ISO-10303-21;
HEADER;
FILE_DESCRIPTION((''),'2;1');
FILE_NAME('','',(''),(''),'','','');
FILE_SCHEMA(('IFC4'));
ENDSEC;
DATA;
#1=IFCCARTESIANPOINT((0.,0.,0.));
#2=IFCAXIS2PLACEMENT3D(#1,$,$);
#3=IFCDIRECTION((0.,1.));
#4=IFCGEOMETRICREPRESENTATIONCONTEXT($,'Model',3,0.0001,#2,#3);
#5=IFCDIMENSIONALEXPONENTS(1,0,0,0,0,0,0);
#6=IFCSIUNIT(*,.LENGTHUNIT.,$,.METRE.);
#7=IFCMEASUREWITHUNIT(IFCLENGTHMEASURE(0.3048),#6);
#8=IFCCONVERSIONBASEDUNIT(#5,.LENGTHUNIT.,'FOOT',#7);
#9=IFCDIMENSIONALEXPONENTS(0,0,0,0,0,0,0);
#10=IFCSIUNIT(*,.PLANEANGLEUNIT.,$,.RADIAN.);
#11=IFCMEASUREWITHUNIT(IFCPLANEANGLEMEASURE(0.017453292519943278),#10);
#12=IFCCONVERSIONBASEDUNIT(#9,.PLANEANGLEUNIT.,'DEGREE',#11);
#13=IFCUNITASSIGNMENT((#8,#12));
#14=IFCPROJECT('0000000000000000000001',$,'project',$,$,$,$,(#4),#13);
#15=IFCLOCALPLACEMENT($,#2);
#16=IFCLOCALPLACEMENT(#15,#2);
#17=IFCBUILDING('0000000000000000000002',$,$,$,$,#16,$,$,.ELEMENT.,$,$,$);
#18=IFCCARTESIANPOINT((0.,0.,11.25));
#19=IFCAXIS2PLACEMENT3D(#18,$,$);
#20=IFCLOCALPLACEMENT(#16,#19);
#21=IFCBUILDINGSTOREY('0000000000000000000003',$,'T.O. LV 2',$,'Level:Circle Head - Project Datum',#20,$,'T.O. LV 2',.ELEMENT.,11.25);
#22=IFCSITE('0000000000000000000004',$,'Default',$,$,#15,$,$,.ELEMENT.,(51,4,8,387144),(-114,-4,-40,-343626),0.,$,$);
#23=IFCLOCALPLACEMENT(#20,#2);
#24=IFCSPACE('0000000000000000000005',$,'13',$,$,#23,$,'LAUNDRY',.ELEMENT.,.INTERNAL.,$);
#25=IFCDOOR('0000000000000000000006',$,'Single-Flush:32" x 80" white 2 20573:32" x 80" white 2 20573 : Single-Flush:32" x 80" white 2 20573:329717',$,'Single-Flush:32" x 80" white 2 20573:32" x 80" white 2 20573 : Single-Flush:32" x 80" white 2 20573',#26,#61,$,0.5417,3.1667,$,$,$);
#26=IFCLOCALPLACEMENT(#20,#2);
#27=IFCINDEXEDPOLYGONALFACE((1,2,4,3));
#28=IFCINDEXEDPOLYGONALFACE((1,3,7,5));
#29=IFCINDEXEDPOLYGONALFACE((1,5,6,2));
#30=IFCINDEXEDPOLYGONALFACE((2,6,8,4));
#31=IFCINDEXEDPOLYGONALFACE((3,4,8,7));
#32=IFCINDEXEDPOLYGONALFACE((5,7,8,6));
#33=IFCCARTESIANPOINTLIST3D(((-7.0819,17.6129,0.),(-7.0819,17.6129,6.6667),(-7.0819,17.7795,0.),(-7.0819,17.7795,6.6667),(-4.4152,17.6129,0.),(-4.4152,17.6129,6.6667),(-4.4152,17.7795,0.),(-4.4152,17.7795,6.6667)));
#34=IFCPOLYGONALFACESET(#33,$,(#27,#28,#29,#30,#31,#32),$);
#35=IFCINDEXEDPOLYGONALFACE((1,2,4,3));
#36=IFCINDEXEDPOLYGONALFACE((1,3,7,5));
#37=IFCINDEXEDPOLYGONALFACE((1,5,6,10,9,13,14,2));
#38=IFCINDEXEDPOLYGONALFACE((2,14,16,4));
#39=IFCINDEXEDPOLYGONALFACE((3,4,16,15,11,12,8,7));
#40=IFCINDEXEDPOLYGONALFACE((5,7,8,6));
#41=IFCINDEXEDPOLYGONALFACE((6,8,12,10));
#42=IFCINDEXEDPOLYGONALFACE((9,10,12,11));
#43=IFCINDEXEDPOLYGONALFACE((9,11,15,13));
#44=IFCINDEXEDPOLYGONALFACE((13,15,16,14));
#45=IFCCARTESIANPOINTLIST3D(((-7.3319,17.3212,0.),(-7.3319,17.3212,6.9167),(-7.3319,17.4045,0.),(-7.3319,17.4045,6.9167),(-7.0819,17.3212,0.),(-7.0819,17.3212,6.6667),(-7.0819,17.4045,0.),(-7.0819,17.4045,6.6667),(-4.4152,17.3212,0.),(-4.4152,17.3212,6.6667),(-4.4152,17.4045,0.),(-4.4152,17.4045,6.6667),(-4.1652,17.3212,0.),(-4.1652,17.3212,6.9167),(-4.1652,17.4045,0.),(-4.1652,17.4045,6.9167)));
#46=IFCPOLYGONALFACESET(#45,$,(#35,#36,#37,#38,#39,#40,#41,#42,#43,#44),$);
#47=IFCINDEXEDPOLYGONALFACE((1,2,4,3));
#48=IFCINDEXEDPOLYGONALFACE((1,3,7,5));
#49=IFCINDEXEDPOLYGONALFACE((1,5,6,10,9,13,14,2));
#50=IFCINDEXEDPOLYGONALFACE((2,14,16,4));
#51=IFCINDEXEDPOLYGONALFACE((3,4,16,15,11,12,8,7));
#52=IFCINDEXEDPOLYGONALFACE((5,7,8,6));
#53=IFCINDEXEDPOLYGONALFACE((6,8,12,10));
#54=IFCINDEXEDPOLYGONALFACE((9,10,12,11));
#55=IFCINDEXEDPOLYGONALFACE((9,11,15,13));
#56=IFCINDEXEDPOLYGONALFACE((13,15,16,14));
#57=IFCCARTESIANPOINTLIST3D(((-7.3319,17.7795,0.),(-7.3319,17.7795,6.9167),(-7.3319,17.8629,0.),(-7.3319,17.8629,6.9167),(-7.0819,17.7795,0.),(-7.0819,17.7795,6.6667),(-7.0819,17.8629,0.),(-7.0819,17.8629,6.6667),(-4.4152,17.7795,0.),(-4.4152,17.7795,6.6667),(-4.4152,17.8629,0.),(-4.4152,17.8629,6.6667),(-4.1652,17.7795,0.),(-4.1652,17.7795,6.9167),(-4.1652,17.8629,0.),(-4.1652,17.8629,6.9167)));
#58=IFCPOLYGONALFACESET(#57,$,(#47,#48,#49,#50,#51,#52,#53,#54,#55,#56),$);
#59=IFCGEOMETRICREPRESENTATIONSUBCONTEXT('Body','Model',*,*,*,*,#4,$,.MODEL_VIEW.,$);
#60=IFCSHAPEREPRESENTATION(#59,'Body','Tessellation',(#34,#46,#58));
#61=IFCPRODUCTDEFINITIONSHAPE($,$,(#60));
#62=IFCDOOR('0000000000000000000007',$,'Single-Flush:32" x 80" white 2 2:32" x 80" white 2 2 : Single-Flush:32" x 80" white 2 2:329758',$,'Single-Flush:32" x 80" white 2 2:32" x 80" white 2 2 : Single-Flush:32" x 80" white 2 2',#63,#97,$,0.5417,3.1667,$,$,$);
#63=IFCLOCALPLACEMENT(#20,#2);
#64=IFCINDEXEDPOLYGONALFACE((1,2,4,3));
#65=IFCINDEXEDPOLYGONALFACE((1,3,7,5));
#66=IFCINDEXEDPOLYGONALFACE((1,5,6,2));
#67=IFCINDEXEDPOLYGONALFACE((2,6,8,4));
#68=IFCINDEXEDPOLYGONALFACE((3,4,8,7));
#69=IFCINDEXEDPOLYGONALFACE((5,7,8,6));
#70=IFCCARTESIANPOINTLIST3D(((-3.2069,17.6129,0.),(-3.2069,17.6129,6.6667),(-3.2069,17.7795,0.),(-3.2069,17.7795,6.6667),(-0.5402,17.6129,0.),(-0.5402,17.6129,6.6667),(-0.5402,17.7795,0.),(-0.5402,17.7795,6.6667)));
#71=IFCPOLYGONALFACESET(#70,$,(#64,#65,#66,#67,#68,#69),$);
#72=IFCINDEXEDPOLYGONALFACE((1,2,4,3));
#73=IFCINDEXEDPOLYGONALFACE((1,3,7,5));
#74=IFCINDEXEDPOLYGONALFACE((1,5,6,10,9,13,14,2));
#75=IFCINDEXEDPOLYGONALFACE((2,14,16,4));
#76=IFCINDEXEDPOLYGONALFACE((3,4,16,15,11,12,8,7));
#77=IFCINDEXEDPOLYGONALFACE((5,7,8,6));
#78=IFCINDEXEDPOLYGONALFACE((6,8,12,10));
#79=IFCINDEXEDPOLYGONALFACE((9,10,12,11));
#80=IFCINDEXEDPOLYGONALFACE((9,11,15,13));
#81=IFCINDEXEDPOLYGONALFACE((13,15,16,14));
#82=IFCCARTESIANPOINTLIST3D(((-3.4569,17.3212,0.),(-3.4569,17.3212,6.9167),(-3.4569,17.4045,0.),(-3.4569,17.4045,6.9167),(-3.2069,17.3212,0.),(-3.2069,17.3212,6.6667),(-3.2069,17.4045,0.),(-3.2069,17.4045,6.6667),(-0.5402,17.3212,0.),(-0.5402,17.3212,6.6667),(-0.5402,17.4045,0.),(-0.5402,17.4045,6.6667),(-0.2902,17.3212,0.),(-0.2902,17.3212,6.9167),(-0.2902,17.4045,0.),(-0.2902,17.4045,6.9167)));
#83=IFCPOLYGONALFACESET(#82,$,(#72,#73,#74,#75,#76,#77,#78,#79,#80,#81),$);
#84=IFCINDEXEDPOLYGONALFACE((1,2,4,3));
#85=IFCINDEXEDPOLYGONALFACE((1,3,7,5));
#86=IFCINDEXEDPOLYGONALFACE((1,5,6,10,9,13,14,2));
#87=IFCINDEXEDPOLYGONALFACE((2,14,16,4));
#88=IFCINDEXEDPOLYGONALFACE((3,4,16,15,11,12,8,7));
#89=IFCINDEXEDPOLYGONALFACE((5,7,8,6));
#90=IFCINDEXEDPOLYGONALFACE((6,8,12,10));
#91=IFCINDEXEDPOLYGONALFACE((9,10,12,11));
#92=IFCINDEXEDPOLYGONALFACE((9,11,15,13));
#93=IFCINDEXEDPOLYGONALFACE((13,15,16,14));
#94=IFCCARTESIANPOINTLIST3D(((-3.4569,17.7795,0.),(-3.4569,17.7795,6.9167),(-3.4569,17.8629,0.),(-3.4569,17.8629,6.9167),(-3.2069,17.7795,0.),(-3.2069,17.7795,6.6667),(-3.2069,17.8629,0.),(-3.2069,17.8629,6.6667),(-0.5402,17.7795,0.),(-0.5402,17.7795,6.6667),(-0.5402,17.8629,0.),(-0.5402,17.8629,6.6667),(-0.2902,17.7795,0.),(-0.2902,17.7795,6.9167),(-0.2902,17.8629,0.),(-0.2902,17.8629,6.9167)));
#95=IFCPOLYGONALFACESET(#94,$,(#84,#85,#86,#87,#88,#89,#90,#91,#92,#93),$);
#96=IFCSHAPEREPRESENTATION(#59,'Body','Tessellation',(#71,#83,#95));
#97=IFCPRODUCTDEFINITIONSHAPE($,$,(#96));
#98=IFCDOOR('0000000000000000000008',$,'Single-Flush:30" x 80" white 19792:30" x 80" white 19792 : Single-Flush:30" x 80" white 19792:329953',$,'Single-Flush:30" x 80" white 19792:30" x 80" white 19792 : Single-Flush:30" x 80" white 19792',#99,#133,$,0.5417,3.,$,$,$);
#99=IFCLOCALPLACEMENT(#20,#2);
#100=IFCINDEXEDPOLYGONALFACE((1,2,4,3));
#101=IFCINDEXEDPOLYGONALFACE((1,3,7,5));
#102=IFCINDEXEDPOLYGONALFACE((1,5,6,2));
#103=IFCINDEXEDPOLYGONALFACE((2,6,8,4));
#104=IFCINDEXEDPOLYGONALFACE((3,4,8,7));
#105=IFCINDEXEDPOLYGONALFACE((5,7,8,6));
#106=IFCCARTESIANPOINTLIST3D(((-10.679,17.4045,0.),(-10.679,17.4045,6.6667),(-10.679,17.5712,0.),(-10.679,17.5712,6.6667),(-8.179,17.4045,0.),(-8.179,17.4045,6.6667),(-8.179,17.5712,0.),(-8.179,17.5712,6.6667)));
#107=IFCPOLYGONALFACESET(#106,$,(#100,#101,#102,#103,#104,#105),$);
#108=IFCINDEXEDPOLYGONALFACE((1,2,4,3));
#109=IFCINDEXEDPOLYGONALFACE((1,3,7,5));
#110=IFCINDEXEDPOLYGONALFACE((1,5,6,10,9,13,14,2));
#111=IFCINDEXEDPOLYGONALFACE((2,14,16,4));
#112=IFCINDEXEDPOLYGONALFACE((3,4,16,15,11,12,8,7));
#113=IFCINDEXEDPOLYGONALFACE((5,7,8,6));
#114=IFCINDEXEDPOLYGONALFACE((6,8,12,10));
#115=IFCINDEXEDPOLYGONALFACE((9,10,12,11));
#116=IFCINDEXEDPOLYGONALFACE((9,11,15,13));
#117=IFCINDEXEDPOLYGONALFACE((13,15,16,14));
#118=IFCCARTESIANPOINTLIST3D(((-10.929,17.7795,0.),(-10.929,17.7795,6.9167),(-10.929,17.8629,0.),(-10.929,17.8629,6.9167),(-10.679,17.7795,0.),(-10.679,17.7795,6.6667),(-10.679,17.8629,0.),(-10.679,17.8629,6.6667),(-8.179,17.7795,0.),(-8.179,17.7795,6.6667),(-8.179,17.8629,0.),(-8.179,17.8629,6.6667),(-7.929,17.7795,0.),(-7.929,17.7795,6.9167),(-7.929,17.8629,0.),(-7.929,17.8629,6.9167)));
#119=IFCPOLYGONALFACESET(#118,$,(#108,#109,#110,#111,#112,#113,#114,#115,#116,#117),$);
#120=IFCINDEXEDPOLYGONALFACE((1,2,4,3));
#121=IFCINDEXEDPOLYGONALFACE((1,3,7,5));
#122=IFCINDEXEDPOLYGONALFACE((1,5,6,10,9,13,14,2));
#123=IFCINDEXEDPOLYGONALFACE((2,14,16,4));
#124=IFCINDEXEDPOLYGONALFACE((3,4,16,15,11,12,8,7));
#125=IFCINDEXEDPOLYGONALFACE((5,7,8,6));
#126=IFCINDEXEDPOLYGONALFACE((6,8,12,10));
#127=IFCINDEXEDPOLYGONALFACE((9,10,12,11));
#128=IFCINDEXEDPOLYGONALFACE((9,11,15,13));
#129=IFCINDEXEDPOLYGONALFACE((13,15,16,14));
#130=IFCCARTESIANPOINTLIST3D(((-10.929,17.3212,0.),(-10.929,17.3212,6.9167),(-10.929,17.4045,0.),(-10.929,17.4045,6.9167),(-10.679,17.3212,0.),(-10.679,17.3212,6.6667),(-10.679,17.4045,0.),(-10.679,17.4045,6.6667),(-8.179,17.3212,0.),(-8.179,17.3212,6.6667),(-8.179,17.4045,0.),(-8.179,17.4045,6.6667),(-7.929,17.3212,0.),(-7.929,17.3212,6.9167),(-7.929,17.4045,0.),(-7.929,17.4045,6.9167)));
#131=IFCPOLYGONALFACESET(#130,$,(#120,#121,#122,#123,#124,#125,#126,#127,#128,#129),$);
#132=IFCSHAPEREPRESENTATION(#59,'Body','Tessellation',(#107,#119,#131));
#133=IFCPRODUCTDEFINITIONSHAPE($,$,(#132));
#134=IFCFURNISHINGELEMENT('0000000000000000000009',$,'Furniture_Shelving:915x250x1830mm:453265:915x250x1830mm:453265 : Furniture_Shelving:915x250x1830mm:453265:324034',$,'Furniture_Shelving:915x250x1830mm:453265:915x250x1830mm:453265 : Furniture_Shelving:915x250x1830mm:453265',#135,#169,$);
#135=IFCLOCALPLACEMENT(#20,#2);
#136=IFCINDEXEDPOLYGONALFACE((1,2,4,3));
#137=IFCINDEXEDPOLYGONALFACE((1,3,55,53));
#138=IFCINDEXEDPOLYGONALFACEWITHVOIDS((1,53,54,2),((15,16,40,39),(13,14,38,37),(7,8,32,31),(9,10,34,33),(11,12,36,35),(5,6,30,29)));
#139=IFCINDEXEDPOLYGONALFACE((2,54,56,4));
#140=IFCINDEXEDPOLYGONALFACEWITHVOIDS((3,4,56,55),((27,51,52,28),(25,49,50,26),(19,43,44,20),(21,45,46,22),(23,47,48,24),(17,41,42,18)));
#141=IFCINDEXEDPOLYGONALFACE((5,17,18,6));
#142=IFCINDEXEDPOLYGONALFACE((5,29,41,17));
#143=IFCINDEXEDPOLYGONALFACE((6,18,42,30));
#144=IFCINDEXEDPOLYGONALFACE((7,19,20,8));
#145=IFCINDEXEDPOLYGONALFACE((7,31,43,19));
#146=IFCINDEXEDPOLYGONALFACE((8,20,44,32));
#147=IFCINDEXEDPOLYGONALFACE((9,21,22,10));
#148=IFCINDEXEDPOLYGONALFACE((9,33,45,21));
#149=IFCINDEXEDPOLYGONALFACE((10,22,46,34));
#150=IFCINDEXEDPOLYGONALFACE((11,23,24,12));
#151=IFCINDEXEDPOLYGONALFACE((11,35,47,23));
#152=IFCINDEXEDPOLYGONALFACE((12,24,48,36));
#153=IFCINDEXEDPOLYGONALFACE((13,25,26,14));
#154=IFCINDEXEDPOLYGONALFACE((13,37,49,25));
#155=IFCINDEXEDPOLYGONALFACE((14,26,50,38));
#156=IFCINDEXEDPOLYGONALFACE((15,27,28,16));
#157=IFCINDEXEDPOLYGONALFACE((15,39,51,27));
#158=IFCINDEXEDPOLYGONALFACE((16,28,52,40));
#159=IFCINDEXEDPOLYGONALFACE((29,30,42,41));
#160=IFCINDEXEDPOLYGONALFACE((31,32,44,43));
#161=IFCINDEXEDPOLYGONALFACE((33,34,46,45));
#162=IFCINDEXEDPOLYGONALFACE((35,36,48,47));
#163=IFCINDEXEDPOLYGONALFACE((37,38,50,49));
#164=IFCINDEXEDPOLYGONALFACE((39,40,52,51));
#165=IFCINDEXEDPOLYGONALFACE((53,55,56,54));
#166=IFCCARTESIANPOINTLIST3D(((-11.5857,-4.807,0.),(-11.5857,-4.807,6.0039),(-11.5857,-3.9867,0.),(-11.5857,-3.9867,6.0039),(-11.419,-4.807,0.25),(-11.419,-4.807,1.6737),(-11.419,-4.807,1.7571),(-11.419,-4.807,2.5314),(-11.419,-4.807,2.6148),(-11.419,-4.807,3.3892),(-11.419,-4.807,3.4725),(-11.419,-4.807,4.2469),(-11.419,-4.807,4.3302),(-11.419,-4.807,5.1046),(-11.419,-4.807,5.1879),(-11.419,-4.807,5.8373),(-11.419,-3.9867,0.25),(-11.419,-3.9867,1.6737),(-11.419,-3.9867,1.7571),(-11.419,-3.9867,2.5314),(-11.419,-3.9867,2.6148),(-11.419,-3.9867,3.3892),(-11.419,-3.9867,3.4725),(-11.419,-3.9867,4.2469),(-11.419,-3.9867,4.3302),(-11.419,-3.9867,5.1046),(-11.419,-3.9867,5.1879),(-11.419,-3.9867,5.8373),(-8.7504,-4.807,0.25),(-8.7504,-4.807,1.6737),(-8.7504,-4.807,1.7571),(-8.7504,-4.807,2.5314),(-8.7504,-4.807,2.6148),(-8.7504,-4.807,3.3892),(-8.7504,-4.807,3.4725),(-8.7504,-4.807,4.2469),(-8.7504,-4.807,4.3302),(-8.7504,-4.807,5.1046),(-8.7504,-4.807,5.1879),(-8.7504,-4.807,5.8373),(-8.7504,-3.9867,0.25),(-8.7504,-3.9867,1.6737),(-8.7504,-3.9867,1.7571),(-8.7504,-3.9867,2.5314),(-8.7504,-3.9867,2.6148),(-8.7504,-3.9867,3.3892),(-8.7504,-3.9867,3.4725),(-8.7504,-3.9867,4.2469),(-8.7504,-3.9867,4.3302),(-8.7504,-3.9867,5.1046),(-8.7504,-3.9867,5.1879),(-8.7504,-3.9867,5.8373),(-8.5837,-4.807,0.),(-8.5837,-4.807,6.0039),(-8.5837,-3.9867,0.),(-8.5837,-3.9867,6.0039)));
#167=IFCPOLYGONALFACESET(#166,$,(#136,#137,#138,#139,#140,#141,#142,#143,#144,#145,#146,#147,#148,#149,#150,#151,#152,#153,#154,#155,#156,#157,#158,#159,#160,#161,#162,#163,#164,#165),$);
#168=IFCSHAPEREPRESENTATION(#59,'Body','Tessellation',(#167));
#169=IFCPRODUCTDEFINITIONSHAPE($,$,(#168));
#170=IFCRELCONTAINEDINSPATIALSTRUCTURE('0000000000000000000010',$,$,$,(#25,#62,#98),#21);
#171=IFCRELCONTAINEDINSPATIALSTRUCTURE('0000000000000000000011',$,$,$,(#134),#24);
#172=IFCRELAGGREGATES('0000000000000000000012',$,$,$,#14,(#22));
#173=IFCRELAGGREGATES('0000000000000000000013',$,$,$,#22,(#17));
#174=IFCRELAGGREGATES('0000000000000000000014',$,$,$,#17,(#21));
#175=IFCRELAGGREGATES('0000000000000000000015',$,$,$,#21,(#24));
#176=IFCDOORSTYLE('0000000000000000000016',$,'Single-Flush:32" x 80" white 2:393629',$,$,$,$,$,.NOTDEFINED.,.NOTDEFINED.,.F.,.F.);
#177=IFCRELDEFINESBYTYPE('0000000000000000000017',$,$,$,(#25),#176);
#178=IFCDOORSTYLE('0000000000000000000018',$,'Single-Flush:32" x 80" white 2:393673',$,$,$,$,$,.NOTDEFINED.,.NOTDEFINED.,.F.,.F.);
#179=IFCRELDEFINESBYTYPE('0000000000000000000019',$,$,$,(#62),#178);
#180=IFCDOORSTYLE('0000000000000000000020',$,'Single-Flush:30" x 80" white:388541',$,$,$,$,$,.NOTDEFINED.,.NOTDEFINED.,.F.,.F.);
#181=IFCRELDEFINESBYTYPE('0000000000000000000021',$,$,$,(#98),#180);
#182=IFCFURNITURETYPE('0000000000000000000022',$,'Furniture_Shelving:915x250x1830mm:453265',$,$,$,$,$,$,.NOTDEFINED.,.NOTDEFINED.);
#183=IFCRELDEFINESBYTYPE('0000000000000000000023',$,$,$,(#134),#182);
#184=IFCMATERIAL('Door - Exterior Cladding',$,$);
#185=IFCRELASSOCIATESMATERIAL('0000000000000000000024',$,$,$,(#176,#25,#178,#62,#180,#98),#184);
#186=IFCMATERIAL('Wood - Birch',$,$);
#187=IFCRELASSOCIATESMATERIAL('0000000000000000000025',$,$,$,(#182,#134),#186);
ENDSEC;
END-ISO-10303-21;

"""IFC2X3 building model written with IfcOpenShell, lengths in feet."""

from ifc_helpers import new_model, entity, si_unit, converted_unit, direction, frame, frame_2d, origin, place, context, subcontext, project, spatial, polyline, rectangle, outline, extrude, source, transform, mapped, material, type_object, type_shapes, element, save


model = new_model("IFC2X3")

# Units and contexts
model_context = context("Model", 3, precision=0.0001, world=origin(), true_north=direction((0.0, 1.0)))
body_context = subcontext(model_context, "Body", "Model", "MODEL_VIEW")
ifc_project = project(units=[converted_unit("LENGTHUNIT", "FOOT", entity("IfcLengthMeasure", 0.3048), si_unit("LENGTHUNIT", "METRE"), dimensions=[1, 0, 0, 0, 0, 0, 0]), converted_unit("PLANEANGLEUNIT", "DEGREE", entity("IfcPlaneAngleMeasure", 0.017453292519943278), si_unit("PLANEANGLEUNIT", "RADIAN"), dimensions=[0, 0, 0, 0, 0, 0, 0])], contexts=[model_context])

# Site, building, storey
site_placement = place(None, origin())
site = spatial("IfcSite", under=ifc_project, at=site_placement, Name="Default", CompositionType="ELEMENT", RefLatitude=(51, 4, 8, 387144), RefLongitude=(-114, -4, -40, -343626), RefElevation=0.0)
building_placement = place(site_placement, origin())
building = spatial("IfcBuilding", under=site, at=building_placement, CompositionType="ELEMENT")
storey_placement = place(building_placement, frame((0.0, 0.0, 11.25)))
storey = spatial("IfcBuildingStorey", under=building, at=storey_placement, Name="T.O. LV 2", ObjectType="Level:Circle Head - Project Datum", LongName="T.O. LV 2", CompositionType="ELEMENT", Elevation=11.25)

# Shared definitions
ifc_material_1 = material(Name="Door - Exterior Cladding")

# Doors
door_style_1 = type_object("IfcDoorStyle", Name="Single-Flush:32\" x 80\" white 2:393629", ConstructionType="NOTDEFINED", OperationType="NOTDEFINED", ParameterTakesPrecedence=False, Sizeable=False, material=ifc_material_1)
shared_shape_1 = source(origin(), body_context, "Body", "SweptSolid", [
    extrude(rectangle(XDim=2.6667, YDim=0.1667, at=frame_2d((0.0, 0.0), x_axis=(1.0, 0.0))), frame((-5.7486, 17.6962, 11.25), z_axis=(0.0, 0.0, 1.0), x_axis=(-1.0, 0.0, 0.0)), (0.0, 0.0, 1.0), 6.6667),
    extrude(outline(polyline([(-1.5833, -3.3958), (-1.3333, -3.3958), (-1.3333, 3.2708), (1.3333, 3.2708), (1.3333, -3.3958), (1.5833, -3.3958), (1.5833, 3.5208), (-1.5833, 3.5208), (-1.5833, -3.3958)])), frame((-5.7486, 17.3212, 14.6458), z_axis=(0.0, 1.0, 0.0), x_axis=(-1.0, 0.0, 0.0)), (0.0, 0.0, 1.0), 0.0833),
    extrude(outline(polyline([(-3.5208, -1.5833), (3.3958, -1.5833), (3.3958, -1.3333), (-3.2708, -1.3333), (-3.2708, 1.3333), (3.3958, 1.3333), (3.3958, 1.5833), (-3.5208, 1.5833), (-3.5208, -1.5833)])), frame((-5.7486, 17.7795, 14.6458), z_axis=(0.0, 1.0, 0.0), x_axis=(0.0, 0.0, -1.0)), (0.0, 0.0, 1.0), 0.0833),
])
type_shapes(door_style_1, [shared_shape_1])
door_1_placement = place(storey_placement, frame((0.0, 0.0, -11.25)))
element("IfcDoor", 1, at=door_1_placement, inside=storey, type_object=door_style_1, material=ifc_material_1, Name="Single-Flush:32\" x 80\" white 2 20573:32\" x 80\" white 2 20573 : Single-Flush:32\" x 80\" white 2 20573:329717", ObjectType="Single-Flush:32\" x 80\" white 2 20573:32\" x 80\" white 2 20573 : Single-Flush:32\" x 80\" white 2 20573", OverallHeight=0.5417, OverallWidth=3.1667, context=body_context, shape_type="MappedRepresentation", body=[
    mapped(shared_shape_1, transform((0.0, 0.0, 0.0), scale=1.0)),
])
door_style_2 = type_object("IfcDoorStyle", Name="Single-Flush:32\" x 80\" white 2:393673", ConstructionType="NOTDEFINED", OperationType="NOTDEFINED", ParameterTakesPrecedence=False, Sizeable=False, material=ifc_material_1)
shared_shape_2 = source(origin(), body_context, "Body", "SweptSolid", [
    extrude(rectangle(XDim=0.1667, YDim=2.6667, at=frame_2d((0.0, 0.0), x_axis=(1.0, 0.0))), frame((-1.8736, 17.6962, 11.25), z_axis=(0.0, 0.0, 1.0), x_axis=(0.0, 1.0, 0.0)), (0.0, 0.0, 1.0), 6.6667),
    extrude(outline(polyline([(-3.3958, -1.5833), (3.5208, -1.5833), (3.5208, 1.5833), (-3.3958, 1.5833), (-3.3958, 1.3333), (3.2708, 1.3333), (3.2708, -1.3333), (-3.3958, -1.3333), (-3.3958, -1.5833)])), frame((-1.8736, 17.3212, 14.6458), z_axis=(0.0, 1.0, 0.0), x_axis=(0.0, 0.0, 1.0)), (0.0, 0.0, 1.0), 0.0833),
    extrude(outline(polyline([(-1.5833, -3.5208), (1.5833, -3.5208), (1.5833, 3.3958), (1.3333, 3.3958), (1.3333, -3.2708), (-1.3333, -3.2708), (-1.3333, 3.3958), (-1.5833, 3.3958), (-1.5833, -3.5208)])), frame((-1.8736, 17.7795, 14.6458), z_axis=(0.0, 1.0, 0.0), x_axis=(1.0, 0.0, 0.0)), (0.0, 0.0, 1.0), 0.0833),
])
type_shapes(door_style_2, [shared_shape_2])
door_2_placement = place(storey_placement, frame((0.0, 0.0, -11.25)))
element("IfcDoor", 2, at=door_2_placement, inside=storey, type_object=door_style_2, material=ifc_material_1, Name="Single-Flush:32\" x 80\" white 2 2:32\" x 80\" white 2 2 : Single-Flush:32\" x 80\" white 2 2:329758", ObjectType="Single-Flush:32\" x 80\" white 2 2:32\" x 80\" white 2 2 : Single-Flush:32\" x 80\" white 2 2", OverallHeight=0.5417, OverallWidth=3.1667, context=body_context, shape_type="MappedRepresentation", body=[
    mapped(shared_shape_2, transform((0.0, 0.0, 0.0), scale=1.0)),
])
door_style_3 = type_object("IfcDoorStyle", Name="Single-Flush:30\" x 80\" white:388541", ConstructionType="NOTDEFINED", OperationType="NOTDEFINED", ParameterTakesPrecedence=False, Sizeable=False, material=ifc_material_1)
shared_shape_3 = source(origin(), body_context, "Body", "SweptSolid", [
    extrude(rectangle(XDim=2.5, YDim=0.1667, at=frame_2d((0.0, 0.0), x_axis=(1.0, 0.0))), frame((-9.429, 17.4879, 11.25)), (0.0, 0.0, 1.0), 6.6667),
    extrude(outline(polyline([(-3.3958, -1.5), (3.5208, -1.5), (3.5208, 1.5), (-3.3958, 1.5), (-3.3958, 1.25), (3.2708, 1.25), (3.2708, -1.25), (-3.3958, -1.25), (-3.3958, -1.5)])), frame((-9.429, 17.7795, 14.6458), z_axis=(0.0, 1.0, 0.0), x_axis=(0.0, 0.0, 1.0)), (0.0, 0.0, 1.0), 0.0833),
    extrude(outline(polyline([(-1.5, -3.5208), (1.5, -3.5208), (1.5, 3.3958), (1.25, 3.3958), (1.25, -3.2708), (-1.25, -3.2708), (-1.25, 3.3958), (-1.5, 3.3958), (-1.5, -3.5208)])), frame((-9.429, 17.3212, 14.6458), z_axis=(0.0, 1.0, 0.0), x_axis=(1.0, 0.0, 0.0)), (0.0, 0.0, 1.0), 0.0833),
])
type_shapes(door_style_3, [shared_shape_3])
door_3_placement = place(storey_placement, frame((0.0, 0.0, -11.25)))
element("IfcDoor", 3, at=door_3_placement, inside=storey, type_object=door_style_3, material=ifc_material_1, Name="Single-Flush:30\" x 80\" white 19792:30\" x 80\" white 19792 : Single-Flush:30\" x 80\" white 19792:329953", ObjectType="Single-Flush:30\" x 80\" white 19792:30\" x 80\" white 19792 : Single-Flush:30\" x 80\" white 19792", OverallHeight=0.5417, OverallWidth=3.0, context=body_context, shape_type="MappedRepresentation", body=[
    mapped(shared_shape_3, transform((0.0, 0.0, 0.0), scale=1.0)),
])

# Shared definitions
space_placement = place(storey_placement, origin())
space = spatial("IfcSpace", under=storey, at=space_placement, Name="13", LongName="LAUNDRY", CompositionType="ELEMENT", InteriorOrExteriorSpace="INTERNAL")

# Furnishing element
ifc_material_2 = material(Name="Wood - Birch")
furniture_type = type_object("IfcFurnitureType", Name="Furniture_Shelving:915x250x1830mm:453265", AssemblyPlace="NOTDEFINED", material=ifc_material_2)
shared_shape_4 = source(origin(), body_context, "Body", "SweptSolid", [
    extrude(outline(polyline([(-3.002, -1.501), (3.002, -1.501), (3.002, 1.501), (-3.002, 1.501), (-3.002, -1.501)]), holes=[polyline([(2.8353, -1.3343), (2.1859, -1.3343), (2.1859, 1.3343), (2.8353, 1.3343), (2.8353, -1.3343)]), polyline([(-1.3282, 1.3343), (-1.3282, -1.3343), (-2.752, -1.3343), (-2.752, 1.3343), (-1.3282, 1.3343)]), polyline([(0.4705, 1.3343), (1.2449, 1.3343), (1.2449, -1.3343), (0.4705, -1.3343), (0.4705, 1.3343)]), polyline([(2.1026, -1.3343), (1.3282, -1.3343), (1.3282, 1.3343), (2.1026, 1.3343), (2.1026, -1.3343)]), polyline([(0.3872, -1.3343), (-0.3872, -1.3343), (-0.3872, 1.3343), (0.3872, 1.3343), (0.3872, -1.3343)]), polyline([(-0.4705, -1.3343), (-1.2449, -1.3343), (-1.2449, 1.3343), (-0.4705, 1.3343), (-0.4705, -1.3343)])]), frame((-10.0847, -4.807, 14.252), z_axis=(0.0, 1.0, 0.0), x_axis=(0.0, 0.0, 1.0)), (0.0, 0.0, 1.0), 0.8202),
])
type_shapes(furniture_type, [shared_shape_4])
furnishing_placement = place(space_placement, frame((0.0, 0.0, -11.25)))
element("IfcFurnishingElement", 4, at=furnishing_placement, inside=space, type_object=furniture_type, material=ifc_material_2, Name="Furniture_Shelving:915x250x1830mm:453265:915x250x1830mm:453265 : Furniture_Shelving:915x250x1830mm:453265:324034", ObjectType="Furniture_Shelving:915x250x1830mm:453265:915x250x1830mm:453265 : Furniture_Shelving:915x250x1830mm:453265", context=body_context, shape_type="MappedRepresentation", body=[
    mapped(shared_shape_4, transform((0.0, 0.0, 0.0), scale=1.0)),
])

save(model, "model.ifc")
